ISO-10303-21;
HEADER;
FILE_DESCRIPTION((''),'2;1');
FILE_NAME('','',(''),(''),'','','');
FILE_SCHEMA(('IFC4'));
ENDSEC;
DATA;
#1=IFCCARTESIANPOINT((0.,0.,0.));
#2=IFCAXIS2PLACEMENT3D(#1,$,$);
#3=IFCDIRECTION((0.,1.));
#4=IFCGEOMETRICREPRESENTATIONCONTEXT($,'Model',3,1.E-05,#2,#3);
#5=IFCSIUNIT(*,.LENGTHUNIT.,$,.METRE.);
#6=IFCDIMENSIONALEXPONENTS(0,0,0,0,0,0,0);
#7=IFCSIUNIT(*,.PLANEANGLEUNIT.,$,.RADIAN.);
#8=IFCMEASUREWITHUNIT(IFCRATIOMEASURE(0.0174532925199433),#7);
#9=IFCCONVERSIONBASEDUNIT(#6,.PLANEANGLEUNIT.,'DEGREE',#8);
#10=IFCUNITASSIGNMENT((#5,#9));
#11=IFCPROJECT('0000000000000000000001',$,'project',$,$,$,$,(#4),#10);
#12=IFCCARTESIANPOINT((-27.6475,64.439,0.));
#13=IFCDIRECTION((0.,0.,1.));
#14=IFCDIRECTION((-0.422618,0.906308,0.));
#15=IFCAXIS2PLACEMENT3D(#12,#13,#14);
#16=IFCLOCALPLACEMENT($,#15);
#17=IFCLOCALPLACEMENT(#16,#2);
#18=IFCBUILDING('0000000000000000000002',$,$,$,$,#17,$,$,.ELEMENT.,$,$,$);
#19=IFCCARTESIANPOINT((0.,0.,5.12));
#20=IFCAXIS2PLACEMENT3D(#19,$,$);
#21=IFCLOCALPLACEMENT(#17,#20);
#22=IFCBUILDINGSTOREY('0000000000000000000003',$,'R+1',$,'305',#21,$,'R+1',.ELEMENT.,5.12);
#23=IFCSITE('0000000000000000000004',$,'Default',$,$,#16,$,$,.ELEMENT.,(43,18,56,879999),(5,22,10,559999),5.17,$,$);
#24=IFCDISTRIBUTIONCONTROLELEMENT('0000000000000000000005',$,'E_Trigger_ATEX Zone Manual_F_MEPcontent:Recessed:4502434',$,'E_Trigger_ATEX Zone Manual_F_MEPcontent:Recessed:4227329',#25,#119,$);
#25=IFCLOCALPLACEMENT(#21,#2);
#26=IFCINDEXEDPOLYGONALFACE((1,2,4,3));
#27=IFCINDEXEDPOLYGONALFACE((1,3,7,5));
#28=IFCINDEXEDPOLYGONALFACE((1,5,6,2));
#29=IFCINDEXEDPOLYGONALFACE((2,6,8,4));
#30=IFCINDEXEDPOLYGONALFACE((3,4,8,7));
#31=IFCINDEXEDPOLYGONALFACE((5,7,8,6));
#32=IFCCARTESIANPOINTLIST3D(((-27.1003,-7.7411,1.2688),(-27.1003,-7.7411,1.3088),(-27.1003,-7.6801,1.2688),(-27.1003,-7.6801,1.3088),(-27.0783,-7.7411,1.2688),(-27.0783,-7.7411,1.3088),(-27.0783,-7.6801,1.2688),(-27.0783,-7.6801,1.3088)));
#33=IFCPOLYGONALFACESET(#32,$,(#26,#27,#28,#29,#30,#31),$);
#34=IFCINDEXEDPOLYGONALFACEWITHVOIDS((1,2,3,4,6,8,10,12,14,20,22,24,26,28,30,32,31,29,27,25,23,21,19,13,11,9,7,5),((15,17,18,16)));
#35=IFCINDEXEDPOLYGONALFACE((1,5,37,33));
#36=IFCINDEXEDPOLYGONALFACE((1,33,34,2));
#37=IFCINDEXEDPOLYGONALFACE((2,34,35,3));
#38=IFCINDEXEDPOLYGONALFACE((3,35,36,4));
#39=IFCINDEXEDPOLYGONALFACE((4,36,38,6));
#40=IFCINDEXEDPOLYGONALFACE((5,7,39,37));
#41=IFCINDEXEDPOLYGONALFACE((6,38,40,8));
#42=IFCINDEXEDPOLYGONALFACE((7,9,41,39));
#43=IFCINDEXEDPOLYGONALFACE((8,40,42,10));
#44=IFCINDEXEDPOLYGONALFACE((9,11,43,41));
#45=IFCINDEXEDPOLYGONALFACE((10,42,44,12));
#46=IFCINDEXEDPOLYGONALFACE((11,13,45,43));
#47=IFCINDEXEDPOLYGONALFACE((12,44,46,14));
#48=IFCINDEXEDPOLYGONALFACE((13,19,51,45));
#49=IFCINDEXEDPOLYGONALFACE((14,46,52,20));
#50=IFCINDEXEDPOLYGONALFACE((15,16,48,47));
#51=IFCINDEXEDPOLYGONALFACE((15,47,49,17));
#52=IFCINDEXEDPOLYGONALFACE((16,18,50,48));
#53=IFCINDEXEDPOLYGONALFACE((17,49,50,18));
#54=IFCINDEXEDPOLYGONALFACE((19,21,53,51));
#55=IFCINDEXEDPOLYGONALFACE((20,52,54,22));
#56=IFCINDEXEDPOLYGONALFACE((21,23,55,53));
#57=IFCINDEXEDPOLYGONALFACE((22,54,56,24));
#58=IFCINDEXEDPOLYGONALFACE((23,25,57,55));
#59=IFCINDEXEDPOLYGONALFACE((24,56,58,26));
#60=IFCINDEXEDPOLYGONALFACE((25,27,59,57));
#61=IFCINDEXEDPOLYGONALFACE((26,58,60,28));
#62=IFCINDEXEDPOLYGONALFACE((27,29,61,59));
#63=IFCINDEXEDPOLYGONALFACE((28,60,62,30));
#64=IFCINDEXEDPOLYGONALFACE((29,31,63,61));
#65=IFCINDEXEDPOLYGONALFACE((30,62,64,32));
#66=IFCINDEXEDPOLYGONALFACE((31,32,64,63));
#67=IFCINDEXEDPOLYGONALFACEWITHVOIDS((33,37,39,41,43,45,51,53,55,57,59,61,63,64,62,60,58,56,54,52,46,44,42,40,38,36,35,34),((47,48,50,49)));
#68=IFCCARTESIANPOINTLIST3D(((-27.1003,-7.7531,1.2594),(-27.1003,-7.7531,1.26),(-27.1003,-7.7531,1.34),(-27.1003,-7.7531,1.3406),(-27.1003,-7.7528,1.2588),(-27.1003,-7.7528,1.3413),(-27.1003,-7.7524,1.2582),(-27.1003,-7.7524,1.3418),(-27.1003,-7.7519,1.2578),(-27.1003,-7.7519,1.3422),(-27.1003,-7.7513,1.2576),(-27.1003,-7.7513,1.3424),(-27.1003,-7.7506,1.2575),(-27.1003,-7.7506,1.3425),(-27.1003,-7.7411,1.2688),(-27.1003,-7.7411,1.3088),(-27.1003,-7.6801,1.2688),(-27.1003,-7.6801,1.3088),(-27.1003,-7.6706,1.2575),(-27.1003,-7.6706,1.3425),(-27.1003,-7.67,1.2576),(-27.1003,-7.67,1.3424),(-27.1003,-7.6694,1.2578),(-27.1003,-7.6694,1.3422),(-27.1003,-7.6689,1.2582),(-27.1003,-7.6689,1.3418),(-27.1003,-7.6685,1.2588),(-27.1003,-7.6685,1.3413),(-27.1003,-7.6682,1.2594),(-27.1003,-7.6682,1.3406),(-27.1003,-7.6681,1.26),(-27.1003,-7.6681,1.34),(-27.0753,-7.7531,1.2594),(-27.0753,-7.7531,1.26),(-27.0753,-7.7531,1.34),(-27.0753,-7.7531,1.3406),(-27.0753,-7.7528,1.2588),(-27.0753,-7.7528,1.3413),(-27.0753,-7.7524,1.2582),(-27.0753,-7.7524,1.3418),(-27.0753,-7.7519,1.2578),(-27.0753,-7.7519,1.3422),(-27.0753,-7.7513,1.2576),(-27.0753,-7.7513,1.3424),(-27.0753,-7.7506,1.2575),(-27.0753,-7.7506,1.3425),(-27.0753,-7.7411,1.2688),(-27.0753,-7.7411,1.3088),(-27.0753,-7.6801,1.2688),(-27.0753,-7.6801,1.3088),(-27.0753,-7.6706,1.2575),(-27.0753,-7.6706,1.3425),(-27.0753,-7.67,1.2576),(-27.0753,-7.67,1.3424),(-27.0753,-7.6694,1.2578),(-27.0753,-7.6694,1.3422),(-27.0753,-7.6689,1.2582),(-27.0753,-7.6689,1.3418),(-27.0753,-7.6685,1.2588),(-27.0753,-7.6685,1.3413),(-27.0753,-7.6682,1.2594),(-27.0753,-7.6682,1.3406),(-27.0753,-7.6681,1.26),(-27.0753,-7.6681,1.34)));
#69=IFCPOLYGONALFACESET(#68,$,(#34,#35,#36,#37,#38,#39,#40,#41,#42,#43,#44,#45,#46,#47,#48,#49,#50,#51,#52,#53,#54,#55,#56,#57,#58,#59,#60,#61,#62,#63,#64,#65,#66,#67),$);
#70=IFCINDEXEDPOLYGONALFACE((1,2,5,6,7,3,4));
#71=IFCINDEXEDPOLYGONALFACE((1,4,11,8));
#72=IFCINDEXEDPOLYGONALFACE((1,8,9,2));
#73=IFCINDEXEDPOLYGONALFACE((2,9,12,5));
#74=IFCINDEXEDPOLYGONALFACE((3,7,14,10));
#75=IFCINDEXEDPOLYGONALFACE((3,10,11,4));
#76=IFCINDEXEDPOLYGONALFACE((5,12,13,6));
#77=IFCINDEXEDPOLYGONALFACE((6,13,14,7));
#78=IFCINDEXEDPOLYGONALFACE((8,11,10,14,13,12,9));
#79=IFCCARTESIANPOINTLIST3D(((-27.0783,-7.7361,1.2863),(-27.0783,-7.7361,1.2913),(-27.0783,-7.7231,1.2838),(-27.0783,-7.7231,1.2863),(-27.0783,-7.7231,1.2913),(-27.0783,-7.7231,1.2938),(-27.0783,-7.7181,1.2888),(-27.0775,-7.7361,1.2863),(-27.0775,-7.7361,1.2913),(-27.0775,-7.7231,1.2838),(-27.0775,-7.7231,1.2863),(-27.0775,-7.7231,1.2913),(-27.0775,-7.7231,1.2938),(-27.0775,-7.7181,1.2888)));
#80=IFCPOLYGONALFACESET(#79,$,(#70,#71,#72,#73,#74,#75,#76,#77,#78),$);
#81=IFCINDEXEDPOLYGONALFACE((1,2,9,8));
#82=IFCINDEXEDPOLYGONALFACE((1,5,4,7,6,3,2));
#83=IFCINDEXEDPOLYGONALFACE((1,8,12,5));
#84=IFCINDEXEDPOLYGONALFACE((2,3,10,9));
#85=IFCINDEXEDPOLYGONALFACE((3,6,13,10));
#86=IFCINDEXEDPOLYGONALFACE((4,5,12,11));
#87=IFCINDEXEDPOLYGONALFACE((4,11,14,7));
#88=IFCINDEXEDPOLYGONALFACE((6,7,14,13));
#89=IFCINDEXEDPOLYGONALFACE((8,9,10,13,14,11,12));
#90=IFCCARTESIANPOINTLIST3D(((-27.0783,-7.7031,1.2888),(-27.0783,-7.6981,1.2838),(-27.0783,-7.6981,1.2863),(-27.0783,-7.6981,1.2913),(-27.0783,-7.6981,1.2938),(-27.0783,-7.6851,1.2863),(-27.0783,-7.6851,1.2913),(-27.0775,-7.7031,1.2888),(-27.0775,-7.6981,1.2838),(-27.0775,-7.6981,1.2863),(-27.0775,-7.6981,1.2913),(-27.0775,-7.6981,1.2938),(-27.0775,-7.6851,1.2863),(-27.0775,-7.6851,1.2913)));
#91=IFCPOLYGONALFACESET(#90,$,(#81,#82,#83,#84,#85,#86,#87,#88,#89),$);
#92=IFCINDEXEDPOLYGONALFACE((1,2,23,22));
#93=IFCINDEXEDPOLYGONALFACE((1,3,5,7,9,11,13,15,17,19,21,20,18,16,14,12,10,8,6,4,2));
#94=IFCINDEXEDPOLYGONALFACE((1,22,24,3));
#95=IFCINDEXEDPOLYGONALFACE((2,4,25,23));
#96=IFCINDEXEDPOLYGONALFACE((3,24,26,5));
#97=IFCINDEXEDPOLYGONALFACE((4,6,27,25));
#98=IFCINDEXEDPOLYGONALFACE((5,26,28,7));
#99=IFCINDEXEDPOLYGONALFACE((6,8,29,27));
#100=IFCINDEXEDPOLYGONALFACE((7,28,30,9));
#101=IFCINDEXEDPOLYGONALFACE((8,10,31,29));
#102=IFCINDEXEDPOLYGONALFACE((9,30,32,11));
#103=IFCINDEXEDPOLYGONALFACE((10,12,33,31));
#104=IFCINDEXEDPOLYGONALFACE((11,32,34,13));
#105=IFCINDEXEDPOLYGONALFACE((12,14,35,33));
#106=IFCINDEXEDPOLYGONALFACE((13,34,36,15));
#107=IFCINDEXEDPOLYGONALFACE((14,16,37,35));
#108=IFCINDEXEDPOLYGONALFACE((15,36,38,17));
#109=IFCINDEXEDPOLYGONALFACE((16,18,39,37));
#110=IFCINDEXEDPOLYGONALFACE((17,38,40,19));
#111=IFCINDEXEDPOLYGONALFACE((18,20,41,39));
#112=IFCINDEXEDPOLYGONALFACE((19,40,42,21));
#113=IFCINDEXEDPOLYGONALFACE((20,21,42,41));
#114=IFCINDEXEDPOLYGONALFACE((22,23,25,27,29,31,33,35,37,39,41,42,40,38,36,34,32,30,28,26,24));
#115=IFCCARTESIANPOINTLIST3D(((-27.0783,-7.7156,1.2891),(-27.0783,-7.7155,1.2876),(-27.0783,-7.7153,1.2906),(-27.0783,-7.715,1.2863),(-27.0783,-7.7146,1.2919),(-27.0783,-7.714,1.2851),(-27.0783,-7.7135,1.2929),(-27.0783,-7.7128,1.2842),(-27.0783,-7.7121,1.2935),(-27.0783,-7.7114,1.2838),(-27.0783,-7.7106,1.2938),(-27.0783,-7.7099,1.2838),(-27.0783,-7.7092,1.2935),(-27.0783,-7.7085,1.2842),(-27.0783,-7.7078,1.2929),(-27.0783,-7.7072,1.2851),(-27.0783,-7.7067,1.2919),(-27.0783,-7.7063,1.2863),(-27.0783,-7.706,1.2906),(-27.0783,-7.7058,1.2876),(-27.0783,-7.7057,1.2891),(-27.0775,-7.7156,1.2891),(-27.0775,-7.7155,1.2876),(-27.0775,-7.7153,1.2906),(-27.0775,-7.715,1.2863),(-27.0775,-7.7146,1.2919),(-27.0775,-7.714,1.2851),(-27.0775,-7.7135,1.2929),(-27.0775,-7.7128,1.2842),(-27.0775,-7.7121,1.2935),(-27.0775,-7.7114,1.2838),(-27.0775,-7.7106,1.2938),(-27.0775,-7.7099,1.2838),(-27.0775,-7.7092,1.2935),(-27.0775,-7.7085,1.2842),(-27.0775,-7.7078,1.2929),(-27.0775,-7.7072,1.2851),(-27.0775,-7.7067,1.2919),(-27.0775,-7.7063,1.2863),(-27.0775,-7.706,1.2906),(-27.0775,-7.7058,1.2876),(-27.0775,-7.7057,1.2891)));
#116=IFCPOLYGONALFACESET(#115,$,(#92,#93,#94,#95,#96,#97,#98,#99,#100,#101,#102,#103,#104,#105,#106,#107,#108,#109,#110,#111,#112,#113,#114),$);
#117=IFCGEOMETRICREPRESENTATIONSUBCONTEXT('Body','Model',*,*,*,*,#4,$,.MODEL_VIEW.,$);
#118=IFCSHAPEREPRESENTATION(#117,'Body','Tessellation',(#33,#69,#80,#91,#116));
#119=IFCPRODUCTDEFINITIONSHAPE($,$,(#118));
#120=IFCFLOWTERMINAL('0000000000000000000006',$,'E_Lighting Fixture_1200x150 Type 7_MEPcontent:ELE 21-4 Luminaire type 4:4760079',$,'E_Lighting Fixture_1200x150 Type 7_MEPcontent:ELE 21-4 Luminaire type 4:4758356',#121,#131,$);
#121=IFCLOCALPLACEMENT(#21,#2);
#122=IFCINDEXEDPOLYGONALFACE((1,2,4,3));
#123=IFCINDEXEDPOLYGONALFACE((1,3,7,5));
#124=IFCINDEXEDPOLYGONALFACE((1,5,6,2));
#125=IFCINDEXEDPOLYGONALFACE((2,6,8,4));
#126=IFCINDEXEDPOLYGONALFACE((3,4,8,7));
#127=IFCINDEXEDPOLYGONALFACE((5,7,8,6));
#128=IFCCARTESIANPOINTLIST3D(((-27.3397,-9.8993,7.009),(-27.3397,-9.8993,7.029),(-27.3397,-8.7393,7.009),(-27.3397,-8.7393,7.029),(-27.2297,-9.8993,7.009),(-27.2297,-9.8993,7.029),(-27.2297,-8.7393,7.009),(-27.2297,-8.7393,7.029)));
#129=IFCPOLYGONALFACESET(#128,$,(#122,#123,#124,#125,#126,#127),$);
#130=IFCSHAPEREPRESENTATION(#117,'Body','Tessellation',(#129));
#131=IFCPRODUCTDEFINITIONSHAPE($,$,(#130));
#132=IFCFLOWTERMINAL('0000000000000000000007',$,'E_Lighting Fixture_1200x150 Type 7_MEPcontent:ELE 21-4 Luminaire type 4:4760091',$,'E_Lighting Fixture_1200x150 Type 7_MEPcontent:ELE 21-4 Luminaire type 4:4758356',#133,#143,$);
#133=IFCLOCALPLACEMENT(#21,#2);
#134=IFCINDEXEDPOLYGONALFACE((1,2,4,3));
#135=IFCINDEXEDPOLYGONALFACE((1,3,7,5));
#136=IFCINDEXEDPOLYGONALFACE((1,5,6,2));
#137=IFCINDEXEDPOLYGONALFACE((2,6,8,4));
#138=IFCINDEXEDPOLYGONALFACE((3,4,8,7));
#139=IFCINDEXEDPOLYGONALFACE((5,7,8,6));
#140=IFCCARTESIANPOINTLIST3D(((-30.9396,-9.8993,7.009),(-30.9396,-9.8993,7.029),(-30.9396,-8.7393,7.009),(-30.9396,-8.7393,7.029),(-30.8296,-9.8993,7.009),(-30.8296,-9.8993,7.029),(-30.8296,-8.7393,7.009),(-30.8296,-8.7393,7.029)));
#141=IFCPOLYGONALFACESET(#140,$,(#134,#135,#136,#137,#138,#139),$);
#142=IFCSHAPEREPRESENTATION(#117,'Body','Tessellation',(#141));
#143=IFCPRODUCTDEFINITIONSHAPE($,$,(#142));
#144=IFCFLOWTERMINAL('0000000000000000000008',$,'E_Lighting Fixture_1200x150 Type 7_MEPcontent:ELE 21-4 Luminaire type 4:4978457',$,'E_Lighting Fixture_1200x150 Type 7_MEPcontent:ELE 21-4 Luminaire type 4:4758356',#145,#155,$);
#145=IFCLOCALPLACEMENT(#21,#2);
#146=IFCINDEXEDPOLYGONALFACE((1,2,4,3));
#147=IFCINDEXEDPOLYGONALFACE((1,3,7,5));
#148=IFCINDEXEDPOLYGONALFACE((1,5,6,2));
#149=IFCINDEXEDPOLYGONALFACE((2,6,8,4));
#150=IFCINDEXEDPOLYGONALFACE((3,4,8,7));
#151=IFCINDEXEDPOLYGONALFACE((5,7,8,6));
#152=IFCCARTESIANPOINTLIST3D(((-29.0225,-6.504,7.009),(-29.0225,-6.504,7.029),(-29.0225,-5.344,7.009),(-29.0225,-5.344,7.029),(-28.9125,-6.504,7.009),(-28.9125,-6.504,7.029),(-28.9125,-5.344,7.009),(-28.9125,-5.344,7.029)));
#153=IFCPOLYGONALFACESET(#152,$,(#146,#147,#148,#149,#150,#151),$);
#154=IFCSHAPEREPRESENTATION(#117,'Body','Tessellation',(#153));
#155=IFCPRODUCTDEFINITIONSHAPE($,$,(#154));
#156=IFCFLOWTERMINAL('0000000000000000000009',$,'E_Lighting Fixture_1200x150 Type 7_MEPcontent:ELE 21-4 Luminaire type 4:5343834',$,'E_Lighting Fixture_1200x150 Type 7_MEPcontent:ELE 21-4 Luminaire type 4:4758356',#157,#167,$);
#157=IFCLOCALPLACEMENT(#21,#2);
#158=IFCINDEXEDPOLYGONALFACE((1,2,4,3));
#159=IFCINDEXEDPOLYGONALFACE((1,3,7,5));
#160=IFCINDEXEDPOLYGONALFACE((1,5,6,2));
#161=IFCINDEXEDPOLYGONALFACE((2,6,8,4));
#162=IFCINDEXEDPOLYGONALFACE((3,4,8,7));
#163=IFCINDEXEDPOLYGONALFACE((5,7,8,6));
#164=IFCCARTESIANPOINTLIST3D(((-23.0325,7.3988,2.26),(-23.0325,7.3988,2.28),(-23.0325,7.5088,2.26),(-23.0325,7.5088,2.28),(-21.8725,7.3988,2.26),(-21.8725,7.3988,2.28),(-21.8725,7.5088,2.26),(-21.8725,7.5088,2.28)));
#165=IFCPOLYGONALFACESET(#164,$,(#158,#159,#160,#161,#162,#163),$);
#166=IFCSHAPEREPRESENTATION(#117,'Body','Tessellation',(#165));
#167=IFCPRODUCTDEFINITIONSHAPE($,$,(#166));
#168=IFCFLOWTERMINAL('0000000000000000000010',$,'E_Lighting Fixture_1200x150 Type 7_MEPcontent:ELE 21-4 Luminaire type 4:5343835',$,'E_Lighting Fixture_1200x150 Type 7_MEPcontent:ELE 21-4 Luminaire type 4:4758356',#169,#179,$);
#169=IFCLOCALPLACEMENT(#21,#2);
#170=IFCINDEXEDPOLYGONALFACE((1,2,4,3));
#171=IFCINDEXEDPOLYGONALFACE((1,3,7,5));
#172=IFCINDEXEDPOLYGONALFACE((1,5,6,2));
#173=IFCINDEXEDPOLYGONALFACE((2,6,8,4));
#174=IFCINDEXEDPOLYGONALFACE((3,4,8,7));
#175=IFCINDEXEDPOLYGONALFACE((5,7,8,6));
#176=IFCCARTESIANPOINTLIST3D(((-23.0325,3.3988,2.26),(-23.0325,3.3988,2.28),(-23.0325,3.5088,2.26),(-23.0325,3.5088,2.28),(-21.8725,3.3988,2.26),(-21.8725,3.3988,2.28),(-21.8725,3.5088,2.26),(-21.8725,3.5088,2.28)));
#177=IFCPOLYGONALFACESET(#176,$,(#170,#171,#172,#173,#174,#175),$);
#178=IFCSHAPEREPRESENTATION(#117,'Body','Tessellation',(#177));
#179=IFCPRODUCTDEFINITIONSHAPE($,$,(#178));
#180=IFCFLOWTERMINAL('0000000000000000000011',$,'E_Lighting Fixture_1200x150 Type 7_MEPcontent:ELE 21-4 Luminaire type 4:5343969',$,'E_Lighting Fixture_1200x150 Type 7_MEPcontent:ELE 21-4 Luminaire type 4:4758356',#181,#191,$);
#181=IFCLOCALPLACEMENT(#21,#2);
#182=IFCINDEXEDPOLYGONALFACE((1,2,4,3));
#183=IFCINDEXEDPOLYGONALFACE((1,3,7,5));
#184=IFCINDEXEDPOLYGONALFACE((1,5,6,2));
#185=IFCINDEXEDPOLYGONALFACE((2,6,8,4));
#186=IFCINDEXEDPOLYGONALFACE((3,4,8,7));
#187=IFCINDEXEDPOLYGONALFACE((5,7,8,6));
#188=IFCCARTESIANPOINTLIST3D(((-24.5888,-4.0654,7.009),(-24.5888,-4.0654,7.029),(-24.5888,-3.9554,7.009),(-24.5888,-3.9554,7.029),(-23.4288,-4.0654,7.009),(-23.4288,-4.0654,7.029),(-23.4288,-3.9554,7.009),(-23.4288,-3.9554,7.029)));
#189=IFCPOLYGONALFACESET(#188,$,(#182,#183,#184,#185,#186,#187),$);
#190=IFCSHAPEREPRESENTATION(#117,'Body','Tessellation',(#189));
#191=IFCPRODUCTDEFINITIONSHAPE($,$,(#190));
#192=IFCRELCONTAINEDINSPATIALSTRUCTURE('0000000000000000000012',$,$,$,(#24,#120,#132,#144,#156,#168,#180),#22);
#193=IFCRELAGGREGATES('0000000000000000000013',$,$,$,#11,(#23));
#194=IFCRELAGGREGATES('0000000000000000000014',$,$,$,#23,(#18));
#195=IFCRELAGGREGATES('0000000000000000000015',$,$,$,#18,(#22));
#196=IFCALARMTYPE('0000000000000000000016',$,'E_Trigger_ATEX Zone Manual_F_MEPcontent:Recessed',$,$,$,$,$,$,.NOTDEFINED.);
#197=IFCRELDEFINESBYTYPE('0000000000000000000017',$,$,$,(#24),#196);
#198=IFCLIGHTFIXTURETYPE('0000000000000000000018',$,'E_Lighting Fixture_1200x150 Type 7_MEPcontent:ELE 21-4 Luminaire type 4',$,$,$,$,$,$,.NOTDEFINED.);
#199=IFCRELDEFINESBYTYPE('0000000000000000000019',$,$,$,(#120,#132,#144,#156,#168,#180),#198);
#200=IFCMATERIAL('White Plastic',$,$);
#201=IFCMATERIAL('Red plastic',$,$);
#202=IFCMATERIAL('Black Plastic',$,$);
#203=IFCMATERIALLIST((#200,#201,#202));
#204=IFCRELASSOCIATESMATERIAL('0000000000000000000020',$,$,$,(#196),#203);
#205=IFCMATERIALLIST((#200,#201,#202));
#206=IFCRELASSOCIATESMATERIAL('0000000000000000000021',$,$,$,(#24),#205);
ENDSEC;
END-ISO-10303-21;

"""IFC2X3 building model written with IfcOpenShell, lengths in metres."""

from ifc_helpers import new_model, entity, si_unit, converted_unit, direction, frame, frame_2d, origin, origin_2d_with_axis, place, context, subcontext, project, spatial, polyline, circle_curve, parameter, trimmed, segment, composite_curve, rectangle, circle, outline, extrude, source, transform, mapped, material, material_list, type_object, type_shapes, element, save


model = new_model("IFC2X3")

# Units and contexts
model_context = context("Model", 3, precision=1e-05, world=origin(), true_north=direction((0.0, 1.0)))
body_context = subcontext(model_context, "Body", "Model", "MODEL_VIEW")
ifc_project = project(units=[si_unit("LENGTHUNIT", "METRE"), converted_unit("PLANEANGLEUNIT", "DEGREE", entity("IfcRatioMeasure", 0.0174532925199433), si_unit("PLANEANGLEUNIT", "RADIAN"), dimensions=[0, 0, 0, 0, 0, 0, 0])], contexts=[model_context])

# Site, building, storey
site_placement = place(None, frame((-27.6475, 64.439, 0.0), z_axis=(0.0, 0.0, 1.0), x_axis=(-0.422618, 0.906308, 0.0)))
site = spatial("IfcSite", under=ifc_project, at=site_placement, Name="Default", CompositionType="ELEMENT", RefLatitude=(43, 18, 56, 879999), RefLongitude=(5, 22, 10, 559999), RefElevation=5.17)
building_placement = place(site_placement, origin())
building = spatial("IfcBuilding", under=site, at=building_placement, CompositionType="ELEMENT")
storey_placement = place(building_placement, frame((0.0, 0.0, 5.12)))
storey = spatial("IfcBuildingStorey", under=building, at=storey_placement, Name="R+1", ObjectType="305", LongName="R+1", CompositionType="ELEMENT", Elevation=5.12)

# Distribution control element
ifc_material_1 = material(Name="White Plastic")
ifc_material_2 = material(Name="Red plastic")
ifc_material_3 = material(Name="Black Plastic")
ifc_material_list_1 = material_list([ifc_material_1, ifc_material_2, ifc_material_3])
ifc_material_list_2 = material_list([ifc_material_1, ifc_material_2, ifc_material_3])
alarm_type_1 = type_object("IfcAlarmType", Name="E_Trigger_ATEX Zone Manual_F_MEPcontent:Recessed", PredefinedType="NOTDEFINED", material=ifc_material_list_2)
shared_shape_1 = source(origin(), body_context, "Body", "SweptSolid", [
    extrude(rectangle(XDim=0.061, YDim=0.04, at=origin_2d_with_axis()), frame((0.0, -0.0112, 0.0), z_axis=(0.0, 0.0, 1.0), x_axis=(-1.0, 0.0, 0.0)), (0.0, 0.0, 1.0), 0.022),
    extrude(outline(composite_curve([segment(polyline([(-0.04, -0.0425), (0.04, -0.0425)]), True, "CONTINUOUS"), segment(trimmed(circle_curve(frame_2d((0.04, -0.04), x_axis=(-1.0, 0.0)), 0.0025), [parameter(90.0)], [parameter(180.0)], True, "PARAMETER"), True, "CONTINUOUS"), segment(polyline([(0.0425, -0.04), (0.0425, 0.04)]), True, "CONTINUOUS"), segment(trimmed(circle_curve(frame_2d((0.04, 0.04), x_axis=(-1.0, 0.0)), 0.0025), [parameter(180.0)], [parameter(270.0)], True, "PARAMETER"), True, "CONTINUOUS"), segment(polyline([(0.04, 0.0425), (-0.04, 0.0425)]), True, "CONTINUOUS"), segment(trimmed(circle_curve(frame_2d((-0.04, 0.04), x_axis=(-1.0, 0.0)), 0.0025), [parameter(270.0)], [parameter(0.0)], True, "PARAMETER"), True, "CONTINUOUS"), segment(polyline([(-0.0425, 0.04), (-0.0425, -0.04)]), True, "CONTINUOUS"), segment(trimmed(circle_curve(frame_2d((-0.04, -0.04), x_axis=(-1.0, 0.0)), 0.0025), [parameter(360.0)], [parameter(90.0)], True, "PARAMETER"), True, "CONTINUOUS")], self_intersect=False), holes=[polyline([(-0.0305, -0.0088), (-0.0305, 0.0312), (0.0305, 0.0312), (0.0305, -0.0088), (-0.0305, -0.0088)])]), frame((0.0, 0.0, 0.0), z_axis=(0.0, 0.0, 1.0), x_axis=(-1.0, 0.0, 0.0)), (0.0, 0.0, 1.0), 0.025),
    extrude(outline(polyline([(-0.01, 0.0025), (-0.01, -0.0025), (0.003, -0.0025), (0.003, -0.005), (0.008, 0.0), (0.003, 0.005), (0.003, 0.0025), (-0.01, 0.0025)])), frame((-0.0155, -0.0112, 0.022), z_axis=(0.0, 0.0, -1.0), x_axis=(1.0, 0.0, 0.0)), (0.0, 0.0, -1.0), 0.0008),
    extrude(outline(polyline([(-0.0014, -0.0057), (0.0057, -0.0057), (0.0057, 0.0014), (0.0039, -0.0004), (-0.0053, 0.0088), (-0.0088, 0.0053), (0.0004, -0.0039), (-0.0014, -0.0057)])), frame((0.0155, -0.0112, 0.022), z_axis=(0.0, 0.0, 1.0), x_axis=(-0.707107, -0.707107, 0.0)), (0.0, 0.0, 1.0), 0.0008),
    extrude(circle(Radius=0.005, at=frame_2d((0.0, 0.0), x_axis=(1.0, 0.0))), frame((0.0, -0.0112, 0.022), z_axis=(0.0, 0.0, 1.0), x_axis=(0.0, 1.0, 0.0)), (0.0, 0.0, 1.0), 0.0008),
])
type_shapes(alarm_type_1, [shared_shape_1])
distribution_control_element_placement = place(storey_placement, frame((-27.1003, -7.7106, 1.3), z_axis=(1.0, 0.0, 0.0), x_axis=(0.0, 1.0, 0.0)))
element("IfcDistributionControlElement", 1, at=distribution_control_element_placement, inside=storey, type_object=alarm_type_1, material=ifc_material_list_1, Name="E_Trigger_ATEX Zone Manual_F_MEPcontent:Recessed:4502434", ObjectType="E_Trigger_ATEX Zone Manual_F_MEPcontent:Recessed:4227329", context=body_context, shape_type="MappedRepresentation", body=[
    mapped(shared_shape_1, transform((0.0, 0.0, 0.0), scale=1.0)),
])

# Flow terminals
light_fixture_type_1 = type_object("IfcLightFixtureType", Name="E_Lighting Fixture_1200x150 Type 7_MEPcontent:ELE 21-4 Luminaire type 4", PredefinedType="NOTDEFINED")
shared_shape_2 = source(origin(), body_context, "Body", "SweptSolid", [
    extrude(rectangle(XDim=0.11, YDim=1.16, at=origin_2d_with_axis()), frame((0.0, 0.0, 0.0), z_axis=(0.0, 0.0, 1.0), x_axis=(0.0, -1.0, 0.0)), (0.0, 0.0, 1.0), 0.02),
])
type_shapes(light_fixture_type_1, [shared_shape_2])
for number, where, z_axis, x_axis, name in (
    (2, (-27.2847, -9.3193, 7.009), (0.0, 0.0, 1.0), (0.0, -1.0, 0.0), "E_Lighting Fixture_1200x150 Type 7_MEPcontent:ELE 21-4 Luminaire type 4:4760079"),
    (3, (-30.8846, -9.3193, 7.009), (0.0, 0.0, 1.0), (0.0, -1.0, 0.0), "E_Lighting Fixture_1200x150 Type 7_MEPcontent:ELE 21-4 Luminaire type 4:4760091"),
    (4, (-28.9675, -5.924, 7.009), (0.0, 0.0, 1.0), (0.0, -1.0, 0.0), "E_Lighting Fixture_1200x150 Type 7_MEPcontent:ELE 21-4 Luminaire type 4:4978457"),
):
    element("IfcFlowTerminal", number, at=place(storey_placement, frame(where, z_axis=z_axis, x_axis=x_axis)), inside=storey, type_object=light_fixture_type_1, Name=name, ObjectType="E_Lighting Fixture_1200x150 Type 7_MEPcontent:ELE 21-4 Luminaire type 4:4758356", context=body_context, shape_type="MappedRepresentation", body=[
        mapped(shared_shape_2, transform((0.0, 0.0, 0.0), scale=1.0)),
    ])
for number, where, name in (
    (5, (-22.4525, 7.4538, 2.26), "E_Lighting Fixture_1200x150 Type 7_MEPcontent:ELE 21-4 Luminaire type 4:5343834"),
    (6, (-22.4525, 3.4538, 2.26), "E_Lighting Fixture_1200x150 Type 7_MEPcontent:ELE 21-4 Luminaire type 4:5343835"),
    (7, (-24.0088, -4.0104, 7.009), "E_Lighting Fixture_1200x150 Type 7_MEPcontent:ELE 21-4 Luminaire type 4:5343969"),
):
    element("IfcFlowTerminal", number, at=place(storey_placement, frame(where)), inside=storey, type_object=light_fixture_type_1, Name=name, ObjectType="E_Lighting Fixture_1200x150 Type 7_MEPcontent:ELE 21-4 Luminaire type 4:4758356", context=body_context, shape_type="MappedRepresentation", body=[
        mapped(shared_shape_2, transform((0.0, 0.0, 0.0), scale=1.0)),
    ])

save(model, "model.ifc")
